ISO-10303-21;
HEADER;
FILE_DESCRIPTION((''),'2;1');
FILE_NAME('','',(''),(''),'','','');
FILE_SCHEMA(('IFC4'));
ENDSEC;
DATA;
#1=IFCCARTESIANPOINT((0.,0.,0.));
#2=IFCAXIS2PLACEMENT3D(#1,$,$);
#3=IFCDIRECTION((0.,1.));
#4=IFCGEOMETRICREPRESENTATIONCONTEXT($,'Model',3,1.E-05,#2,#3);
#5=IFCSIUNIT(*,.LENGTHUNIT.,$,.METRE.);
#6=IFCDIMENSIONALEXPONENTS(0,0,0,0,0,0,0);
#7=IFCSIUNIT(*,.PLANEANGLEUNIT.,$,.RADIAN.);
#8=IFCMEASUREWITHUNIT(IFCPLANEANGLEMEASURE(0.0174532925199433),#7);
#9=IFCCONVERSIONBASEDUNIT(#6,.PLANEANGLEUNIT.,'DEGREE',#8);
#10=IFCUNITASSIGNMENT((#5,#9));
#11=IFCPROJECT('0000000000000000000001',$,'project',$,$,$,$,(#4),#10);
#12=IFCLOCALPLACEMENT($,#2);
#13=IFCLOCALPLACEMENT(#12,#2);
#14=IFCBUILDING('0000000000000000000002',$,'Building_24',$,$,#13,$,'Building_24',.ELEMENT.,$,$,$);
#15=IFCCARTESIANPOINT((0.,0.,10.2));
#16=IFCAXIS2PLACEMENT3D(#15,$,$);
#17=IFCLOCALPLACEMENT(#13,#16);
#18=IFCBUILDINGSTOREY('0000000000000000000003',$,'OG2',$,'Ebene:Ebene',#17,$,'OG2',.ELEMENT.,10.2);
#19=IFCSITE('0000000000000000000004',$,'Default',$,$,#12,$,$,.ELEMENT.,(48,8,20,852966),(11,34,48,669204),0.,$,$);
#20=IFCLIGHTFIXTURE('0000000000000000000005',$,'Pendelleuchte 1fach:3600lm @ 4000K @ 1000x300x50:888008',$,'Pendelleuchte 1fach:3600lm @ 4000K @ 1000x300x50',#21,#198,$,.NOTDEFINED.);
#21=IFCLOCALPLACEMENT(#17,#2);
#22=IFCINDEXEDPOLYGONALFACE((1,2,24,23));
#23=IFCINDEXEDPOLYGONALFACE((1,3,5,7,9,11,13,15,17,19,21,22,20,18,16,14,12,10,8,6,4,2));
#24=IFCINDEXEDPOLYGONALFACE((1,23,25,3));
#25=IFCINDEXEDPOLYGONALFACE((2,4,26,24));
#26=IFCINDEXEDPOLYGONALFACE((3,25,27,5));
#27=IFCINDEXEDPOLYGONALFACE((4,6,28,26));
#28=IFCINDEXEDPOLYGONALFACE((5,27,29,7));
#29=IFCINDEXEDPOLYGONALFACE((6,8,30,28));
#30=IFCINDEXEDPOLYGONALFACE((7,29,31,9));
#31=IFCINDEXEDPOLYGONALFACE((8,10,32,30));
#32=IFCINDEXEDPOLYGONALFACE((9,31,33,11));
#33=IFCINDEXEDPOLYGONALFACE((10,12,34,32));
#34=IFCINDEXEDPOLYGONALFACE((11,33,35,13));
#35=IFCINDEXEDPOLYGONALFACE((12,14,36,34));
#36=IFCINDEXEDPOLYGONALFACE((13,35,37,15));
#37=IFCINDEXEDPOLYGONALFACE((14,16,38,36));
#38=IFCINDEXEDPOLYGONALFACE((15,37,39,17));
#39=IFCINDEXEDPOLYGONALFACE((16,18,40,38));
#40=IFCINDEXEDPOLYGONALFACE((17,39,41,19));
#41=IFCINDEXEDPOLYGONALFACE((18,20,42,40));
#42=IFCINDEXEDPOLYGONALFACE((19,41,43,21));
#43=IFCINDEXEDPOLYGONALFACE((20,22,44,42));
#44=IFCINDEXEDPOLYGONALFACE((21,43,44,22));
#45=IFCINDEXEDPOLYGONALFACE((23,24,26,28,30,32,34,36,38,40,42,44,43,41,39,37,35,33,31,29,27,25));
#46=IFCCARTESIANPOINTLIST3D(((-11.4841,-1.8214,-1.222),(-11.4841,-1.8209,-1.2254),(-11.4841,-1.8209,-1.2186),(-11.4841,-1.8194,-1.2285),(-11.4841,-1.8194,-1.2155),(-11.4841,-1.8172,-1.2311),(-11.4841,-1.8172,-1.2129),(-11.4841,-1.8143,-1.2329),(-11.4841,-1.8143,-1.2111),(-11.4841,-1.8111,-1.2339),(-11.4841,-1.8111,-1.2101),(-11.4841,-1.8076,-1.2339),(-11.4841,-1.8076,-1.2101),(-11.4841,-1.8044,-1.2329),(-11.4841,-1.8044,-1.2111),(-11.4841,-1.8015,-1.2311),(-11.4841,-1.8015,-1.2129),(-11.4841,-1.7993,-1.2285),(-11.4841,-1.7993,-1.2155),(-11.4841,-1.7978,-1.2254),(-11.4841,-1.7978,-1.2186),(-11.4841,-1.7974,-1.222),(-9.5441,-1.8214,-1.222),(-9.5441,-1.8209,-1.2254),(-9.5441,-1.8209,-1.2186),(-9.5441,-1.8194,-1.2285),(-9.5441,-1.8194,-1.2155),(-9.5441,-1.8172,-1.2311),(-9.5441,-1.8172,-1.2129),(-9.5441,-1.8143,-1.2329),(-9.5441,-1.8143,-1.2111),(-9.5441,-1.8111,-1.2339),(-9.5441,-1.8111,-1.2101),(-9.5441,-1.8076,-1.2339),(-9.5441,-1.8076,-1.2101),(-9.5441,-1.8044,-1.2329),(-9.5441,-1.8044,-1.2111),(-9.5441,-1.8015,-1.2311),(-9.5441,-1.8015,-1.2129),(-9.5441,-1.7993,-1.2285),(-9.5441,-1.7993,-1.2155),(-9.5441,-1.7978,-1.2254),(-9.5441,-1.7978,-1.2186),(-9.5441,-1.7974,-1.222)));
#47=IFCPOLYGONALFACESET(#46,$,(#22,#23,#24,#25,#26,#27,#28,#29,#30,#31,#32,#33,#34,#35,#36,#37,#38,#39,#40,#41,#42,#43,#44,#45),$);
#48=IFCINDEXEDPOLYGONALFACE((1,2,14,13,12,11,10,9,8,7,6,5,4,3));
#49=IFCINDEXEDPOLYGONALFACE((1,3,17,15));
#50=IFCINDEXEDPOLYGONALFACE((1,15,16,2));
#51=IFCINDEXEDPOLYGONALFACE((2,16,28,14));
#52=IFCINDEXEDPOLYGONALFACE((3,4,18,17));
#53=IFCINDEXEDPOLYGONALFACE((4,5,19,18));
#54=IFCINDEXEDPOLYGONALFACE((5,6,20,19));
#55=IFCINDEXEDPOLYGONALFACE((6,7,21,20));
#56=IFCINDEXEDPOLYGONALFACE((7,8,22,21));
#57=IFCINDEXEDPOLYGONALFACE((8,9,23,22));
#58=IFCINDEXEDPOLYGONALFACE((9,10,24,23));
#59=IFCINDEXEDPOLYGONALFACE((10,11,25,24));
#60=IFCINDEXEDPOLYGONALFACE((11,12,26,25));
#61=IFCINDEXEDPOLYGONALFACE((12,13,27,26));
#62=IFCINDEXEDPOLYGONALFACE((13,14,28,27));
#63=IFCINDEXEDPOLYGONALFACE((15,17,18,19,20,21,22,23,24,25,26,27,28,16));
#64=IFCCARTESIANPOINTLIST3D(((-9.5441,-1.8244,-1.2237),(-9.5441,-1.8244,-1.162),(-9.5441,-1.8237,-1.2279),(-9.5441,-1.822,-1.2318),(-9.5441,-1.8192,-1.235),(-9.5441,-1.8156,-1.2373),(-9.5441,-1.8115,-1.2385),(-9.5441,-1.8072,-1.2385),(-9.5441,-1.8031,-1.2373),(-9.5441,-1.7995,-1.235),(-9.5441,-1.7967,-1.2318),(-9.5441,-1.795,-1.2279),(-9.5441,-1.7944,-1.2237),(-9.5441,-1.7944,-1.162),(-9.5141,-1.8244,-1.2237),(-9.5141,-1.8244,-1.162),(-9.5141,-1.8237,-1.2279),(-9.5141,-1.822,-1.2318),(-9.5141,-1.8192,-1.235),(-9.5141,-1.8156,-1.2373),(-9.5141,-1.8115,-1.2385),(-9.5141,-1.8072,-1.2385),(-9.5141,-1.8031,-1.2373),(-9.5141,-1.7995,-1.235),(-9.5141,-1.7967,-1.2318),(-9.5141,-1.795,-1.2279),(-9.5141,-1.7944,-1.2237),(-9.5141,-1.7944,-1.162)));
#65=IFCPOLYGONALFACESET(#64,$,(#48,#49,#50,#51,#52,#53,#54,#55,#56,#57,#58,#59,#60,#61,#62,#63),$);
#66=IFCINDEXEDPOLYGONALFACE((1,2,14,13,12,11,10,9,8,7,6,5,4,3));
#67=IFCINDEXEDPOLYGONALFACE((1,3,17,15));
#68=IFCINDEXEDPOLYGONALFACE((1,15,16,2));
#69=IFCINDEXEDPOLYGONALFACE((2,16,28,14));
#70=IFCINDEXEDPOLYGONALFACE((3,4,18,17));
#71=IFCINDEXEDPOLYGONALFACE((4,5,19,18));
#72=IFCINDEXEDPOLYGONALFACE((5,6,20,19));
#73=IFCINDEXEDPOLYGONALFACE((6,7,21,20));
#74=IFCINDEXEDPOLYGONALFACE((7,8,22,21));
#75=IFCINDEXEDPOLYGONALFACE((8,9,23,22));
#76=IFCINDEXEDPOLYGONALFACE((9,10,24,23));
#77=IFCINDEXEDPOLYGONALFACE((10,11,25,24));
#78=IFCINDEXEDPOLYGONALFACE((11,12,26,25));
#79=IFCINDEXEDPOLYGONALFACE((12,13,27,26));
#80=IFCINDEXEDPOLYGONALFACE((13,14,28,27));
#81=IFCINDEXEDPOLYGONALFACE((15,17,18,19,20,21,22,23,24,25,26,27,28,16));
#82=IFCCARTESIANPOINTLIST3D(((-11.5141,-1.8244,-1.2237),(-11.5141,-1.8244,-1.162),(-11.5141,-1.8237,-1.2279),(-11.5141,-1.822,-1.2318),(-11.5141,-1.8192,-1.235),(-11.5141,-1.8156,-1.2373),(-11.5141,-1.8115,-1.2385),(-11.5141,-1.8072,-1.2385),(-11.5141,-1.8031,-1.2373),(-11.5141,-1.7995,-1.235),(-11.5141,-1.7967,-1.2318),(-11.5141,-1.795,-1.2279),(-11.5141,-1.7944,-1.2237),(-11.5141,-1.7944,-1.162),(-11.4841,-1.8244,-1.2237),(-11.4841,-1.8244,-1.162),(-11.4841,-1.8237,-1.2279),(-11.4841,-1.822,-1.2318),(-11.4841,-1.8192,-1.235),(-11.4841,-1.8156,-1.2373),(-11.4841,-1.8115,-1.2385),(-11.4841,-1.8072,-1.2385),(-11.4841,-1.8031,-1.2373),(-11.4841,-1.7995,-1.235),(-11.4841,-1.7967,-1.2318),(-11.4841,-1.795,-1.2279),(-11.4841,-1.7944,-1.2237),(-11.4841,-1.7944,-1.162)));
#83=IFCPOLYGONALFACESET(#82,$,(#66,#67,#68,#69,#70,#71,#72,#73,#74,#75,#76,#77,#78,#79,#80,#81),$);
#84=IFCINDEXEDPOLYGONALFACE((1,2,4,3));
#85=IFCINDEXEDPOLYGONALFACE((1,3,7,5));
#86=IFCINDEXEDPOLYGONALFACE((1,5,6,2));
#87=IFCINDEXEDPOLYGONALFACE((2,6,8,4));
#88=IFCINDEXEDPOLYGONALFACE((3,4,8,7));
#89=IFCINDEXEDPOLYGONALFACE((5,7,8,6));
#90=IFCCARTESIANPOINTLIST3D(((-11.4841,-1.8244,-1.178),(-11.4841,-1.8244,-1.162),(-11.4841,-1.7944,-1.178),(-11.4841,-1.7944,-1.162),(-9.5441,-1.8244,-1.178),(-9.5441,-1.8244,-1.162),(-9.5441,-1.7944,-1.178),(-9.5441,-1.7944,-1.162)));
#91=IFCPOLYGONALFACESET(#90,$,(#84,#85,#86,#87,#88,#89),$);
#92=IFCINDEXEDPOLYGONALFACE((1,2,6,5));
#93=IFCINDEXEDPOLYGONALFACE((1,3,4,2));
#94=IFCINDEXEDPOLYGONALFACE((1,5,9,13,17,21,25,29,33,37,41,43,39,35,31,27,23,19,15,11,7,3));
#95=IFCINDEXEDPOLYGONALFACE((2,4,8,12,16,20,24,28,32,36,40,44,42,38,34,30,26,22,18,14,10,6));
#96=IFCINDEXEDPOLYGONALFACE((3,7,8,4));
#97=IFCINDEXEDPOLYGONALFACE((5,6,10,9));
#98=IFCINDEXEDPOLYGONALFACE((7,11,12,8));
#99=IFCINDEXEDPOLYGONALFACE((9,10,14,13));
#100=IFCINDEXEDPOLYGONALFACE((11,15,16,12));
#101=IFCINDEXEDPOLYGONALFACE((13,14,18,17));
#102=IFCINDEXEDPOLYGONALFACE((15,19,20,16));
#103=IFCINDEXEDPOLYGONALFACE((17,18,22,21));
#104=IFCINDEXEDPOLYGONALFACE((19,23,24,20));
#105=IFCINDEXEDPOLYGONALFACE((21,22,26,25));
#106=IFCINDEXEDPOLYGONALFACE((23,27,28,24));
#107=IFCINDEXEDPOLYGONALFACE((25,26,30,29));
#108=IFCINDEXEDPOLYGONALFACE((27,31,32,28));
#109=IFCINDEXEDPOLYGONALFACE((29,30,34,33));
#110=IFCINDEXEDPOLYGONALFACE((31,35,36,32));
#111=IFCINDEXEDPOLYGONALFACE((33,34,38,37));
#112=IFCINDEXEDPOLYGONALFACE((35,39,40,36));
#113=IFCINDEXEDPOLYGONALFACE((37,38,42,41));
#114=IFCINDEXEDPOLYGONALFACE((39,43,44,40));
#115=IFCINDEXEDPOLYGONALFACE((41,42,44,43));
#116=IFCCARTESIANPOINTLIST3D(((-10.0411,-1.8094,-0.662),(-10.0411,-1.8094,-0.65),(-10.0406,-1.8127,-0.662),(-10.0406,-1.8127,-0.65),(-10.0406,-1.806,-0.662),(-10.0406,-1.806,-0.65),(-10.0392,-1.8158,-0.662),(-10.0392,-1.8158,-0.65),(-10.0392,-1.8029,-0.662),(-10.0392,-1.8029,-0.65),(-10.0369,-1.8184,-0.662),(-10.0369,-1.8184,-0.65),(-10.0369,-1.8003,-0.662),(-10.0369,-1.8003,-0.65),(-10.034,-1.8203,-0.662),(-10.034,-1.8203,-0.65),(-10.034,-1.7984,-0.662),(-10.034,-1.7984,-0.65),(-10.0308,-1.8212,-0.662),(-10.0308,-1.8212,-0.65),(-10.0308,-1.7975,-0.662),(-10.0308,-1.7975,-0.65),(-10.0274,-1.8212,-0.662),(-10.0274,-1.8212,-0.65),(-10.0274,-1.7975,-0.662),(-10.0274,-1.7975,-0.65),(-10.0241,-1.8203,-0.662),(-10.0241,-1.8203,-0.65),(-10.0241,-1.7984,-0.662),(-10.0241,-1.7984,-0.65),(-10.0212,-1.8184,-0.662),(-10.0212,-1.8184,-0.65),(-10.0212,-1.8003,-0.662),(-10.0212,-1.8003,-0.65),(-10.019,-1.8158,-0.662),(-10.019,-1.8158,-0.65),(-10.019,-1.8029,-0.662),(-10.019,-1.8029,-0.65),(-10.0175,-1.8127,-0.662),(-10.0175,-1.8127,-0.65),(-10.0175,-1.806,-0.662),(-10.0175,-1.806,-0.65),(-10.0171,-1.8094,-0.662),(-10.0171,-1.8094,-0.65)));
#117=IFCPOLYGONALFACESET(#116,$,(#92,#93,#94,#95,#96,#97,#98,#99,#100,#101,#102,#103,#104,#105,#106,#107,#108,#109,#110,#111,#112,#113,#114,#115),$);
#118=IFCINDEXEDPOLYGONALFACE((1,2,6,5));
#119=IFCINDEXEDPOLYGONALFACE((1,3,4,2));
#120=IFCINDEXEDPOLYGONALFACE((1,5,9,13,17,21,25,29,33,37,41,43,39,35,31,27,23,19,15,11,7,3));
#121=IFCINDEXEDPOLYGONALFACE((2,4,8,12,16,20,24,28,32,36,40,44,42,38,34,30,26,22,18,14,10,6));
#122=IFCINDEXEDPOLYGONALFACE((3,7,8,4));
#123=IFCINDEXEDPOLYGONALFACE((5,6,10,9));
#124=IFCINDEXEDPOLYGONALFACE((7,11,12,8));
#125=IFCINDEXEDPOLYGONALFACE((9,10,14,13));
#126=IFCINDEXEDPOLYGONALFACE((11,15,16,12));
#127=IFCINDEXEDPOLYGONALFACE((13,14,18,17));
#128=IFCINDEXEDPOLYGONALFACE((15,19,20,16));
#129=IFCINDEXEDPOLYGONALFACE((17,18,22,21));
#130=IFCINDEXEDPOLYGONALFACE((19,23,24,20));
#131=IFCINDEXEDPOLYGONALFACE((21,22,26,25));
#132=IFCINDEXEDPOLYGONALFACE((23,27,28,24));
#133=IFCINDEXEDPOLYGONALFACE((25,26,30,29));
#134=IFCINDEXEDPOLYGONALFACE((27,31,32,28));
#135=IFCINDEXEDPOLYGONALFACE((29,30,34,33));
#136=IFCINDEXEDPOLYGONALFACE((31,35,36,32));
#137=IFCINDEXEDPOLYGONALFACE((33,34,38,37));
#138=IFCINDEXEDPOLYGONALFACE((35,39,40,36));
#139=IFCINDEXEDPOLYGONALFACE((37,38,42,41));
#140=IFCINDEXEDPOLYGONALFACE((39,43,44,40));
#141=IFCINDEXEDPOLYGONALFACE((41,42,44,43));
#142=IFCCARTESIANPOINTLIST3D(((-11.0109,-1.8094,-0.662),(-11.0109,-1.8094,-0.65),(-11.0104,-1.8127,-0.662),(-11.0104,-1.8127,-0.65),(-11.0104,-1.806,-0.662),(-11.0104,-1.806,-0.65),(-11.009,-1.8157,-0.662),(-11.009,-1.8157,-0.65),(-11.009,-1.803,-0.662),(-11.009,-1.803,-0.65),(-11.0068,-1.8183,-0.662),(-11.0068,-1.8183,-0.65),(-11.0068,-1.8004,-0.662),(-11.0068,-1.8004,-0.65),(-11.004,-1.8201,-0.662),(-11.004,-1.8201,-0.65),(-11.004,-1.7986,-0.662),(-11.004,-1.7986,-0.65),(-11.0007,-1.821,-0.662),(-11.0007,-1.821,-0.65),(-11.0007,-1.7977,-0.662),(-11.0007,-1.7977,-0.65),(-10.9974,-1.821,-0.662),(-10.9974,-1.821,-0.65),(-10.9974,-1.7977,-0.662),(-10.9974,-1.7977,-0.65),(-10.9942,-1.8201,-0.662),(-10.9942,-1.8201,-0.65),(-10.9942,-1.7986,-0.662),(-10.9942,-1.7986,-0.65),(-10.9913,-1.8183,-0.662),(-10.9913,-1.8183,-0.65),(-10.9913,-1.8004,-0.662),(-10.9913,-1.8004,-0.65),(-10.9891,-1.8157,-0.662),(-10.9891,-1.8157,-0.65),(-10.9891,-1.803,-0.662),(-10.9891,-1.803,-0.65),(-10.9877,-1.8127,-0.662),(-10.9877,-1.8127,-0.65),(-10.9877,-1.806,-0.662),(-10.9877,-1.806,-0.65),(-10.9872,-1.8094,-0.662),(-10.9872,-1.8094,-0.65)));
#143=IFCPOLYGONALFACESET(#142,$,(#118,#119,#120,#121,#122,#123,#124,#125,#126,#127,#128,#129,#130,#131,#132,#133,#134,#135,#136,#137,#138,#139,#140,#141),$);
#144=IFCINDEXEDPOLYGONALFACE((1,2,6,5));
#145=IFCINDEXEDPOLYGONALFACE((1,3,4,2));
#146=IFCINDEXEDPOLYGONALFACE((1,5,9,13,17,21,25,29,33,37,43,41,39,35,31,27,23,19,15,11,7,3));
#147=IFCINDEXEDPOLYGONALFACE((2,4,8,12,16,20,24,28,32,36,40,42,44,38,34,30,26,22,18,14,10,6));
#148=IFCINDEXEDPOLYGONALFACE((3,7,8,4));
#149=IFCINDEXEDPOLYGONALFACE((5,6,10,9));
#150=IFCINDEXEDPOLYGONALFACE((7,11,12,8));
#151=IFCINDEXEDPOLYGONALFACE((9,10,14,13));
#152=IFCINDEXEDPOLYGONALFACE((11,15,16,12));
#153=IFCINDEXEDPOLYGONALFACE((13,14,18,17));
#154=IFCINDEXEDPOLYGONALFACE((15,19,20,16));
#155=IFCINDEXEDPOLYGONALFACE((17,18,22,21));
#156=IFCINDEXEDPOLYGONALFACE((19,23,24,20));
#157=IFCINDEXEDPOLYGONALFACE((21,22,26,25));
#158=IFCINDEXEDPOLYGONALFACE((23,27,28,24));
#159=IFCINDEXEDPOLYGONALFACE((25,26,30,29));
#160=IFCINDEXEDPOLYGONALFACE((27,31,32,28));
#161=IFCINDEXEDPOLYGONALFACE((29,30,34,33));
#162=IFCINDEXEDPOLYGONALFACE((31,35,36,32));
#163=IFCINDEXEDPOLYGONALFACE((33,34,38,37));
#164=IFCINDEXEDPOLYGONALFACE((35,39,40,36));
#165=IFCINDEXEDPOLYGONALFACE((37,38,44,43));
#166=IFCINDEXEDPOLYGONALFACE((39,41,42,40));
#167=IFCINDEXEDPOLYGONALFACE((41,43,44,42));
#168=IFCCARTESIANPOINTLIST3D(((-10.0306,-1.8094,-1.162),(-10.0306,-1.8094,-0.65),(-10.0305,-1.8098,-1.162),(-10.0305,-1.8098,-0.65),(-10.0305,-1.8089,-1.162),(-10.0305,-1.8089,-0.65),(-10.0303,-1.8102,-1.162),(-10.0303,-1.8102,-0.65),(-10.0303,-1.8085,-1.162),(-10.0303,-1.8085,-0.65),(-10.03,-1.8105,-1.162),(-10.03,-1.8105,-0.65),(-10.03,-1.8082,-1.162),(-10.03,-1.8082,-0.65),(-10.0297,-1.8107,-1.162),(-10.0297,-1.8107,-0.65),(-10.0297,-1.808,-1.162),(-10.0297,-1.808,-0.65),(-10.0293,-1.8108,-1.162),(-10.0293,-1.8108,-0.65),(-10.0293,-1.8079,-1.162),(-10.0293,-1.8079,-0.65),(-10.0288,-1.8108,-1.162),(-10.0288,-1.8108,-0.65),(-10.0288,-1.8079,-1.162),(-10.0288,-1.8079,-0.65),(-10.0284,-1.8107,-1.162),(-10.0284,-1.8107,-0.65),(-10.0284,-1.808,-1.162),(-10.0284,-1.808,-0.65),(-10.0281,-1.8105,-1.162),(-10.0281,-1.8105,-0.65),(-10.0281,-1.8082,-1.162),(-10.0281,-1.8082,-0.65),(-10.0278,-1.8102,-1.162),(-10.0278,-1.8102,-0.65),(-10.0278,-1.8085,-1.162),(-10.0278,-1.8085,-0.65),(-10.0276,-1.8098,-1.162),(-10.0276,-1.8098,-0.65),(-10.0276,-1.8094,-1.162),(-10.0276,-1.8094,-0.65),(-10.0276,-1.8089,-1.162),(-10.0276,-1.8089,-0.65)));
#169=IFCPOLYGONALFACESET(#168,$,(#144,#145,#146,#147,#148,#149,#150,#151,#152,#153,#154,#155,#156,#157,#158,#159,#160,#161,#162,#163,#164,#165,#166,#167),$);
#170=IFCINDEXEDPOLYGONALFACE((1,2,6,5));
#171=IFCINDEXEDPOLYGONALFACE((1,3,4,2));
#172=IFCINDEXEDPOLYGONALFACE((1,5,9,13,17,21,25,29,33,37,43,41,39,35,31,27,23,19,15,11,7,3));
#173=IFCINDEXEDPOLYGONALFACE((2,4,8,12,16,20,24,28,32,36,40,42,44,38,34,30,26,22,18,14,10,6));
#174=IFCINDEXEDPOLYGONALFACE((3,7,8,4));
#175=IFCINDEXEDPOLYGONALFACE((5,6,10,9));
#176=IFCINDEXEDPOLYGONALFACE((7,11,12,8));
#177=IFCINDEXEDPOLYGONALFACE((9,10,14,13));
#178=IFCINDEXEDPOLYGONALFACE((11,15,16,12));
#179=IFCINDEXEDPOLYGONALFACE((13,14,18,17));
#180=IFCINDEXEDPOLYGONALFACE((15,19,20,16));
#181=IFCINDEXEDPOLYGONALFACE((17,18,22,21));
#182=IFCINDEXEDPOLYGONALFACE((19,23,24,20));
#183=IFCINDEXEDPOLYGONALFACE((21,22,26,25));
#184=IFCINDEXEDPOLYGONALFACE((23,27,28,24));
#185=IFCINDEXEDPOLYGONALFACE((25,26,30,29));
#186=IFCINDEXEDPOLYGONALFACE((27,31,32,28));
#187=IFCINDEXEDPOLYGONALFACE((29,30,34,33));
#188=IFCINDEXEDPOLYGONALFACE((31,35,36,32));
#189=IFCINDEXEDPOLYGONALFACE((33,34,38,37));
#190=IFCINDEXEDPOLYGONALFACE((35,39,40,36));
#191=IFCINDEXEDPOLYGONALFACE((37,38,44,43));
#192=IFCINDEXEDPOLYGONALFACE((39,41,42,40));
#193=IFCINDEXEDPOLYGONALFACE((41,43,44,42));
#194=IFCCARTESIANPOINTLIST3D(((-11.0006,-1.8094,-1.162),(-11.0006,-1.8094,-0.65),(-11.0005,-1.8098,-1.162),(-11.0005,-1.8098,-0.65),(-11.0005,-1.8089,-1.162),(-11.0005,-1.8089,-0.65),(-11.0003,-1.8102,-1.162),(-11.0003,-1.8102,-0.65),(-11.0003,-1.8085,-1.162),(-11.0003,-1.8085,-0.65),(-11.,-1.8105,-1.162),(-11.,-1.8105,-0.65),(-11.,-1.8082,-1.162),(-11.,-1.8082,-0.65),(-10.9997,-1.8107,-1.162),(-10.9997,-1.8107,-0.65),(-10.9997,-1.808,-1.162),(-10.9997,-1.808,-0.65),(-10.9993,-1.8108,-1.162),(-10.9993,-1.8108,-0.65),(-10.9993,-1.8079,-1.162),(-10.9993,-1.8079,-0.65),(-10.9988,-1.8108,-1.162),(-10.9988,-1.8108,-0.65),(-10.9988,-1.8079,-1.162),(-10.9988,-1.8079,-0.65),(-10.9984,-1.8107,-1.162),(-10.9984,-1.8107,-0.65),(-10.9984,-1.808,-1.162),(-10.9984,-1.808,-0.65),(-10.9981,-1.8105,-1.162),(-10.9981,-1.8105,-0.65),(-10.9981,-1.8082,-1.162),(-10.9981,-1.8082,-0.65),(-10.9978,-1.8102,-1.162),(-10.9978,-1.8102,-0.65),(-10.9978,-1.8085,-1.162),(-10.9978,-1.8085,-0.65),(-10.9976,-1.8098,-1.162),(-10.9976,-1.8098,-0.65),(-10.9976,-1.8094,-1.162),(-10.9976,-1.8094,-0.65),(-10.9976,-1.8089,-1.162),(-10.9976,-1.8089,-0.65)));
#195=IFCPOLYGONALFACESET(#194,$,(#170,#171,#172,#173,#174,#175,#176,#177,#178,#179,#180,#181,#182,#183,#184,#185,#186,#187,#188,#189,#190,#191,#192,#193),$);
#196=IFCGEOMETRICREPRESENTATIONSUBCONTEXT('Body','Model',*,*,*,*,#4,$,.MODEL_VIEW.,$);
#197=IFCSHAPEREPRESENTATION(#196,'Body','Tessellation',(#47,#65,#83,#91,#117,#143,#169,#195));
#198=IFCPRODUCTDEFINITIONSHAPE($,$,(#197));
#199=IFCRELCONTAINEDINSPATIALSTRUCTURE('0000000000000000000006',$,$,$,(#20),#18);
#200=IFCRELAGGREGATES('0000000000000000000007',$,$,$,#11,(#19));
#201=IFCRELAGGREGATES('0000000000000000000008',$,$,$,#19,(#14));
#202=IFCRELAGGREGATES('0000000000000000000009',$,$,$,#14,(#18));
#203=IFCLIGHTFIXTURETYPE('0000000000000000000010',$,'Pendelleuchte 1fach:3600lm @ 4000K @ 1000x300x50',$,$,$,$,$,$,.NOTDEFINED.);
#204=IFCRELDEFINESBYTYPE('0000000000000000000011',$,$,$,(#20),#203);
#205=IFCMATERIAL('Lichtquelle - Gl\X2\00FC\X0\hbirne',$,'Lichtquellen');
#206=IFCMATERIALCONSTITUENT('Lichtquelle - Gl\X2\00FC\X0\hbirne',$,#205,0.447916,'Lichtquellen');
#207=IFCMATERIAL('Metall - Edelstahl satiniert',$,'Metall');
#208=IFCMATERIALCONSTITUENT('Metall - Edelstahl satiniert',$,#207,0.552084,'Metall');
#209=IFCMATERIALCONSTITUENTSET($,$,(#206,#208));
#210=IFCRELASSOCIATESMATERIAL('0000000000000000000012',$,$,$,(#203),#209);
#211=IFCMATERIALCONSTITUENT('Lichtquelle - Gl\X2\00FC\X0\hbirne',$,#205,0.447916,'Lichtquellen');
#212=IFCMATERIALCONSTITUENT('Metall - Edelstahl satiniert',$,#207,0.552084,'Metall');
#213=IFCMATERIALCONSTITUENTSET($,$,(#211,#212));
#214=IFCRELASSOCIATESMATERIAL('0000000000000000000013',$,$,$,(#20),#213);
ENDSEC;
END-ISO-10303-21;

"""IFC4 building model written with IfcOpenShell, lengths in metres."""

from ifc_helpers import new_model, entity, si_unit, converted_unit, direction, frame, origin, place, context, subcontext, project, spatial, line, arc, indexed_curve, outline, extrude, source, transform, mapped, material, constituent, constituent_set, type_object, type_shapes, element, save


model = new_model("IFC4")

# Units and contexts
model_context = context("Model", 3, precision=1e-05, world=origin(), true_north=direction((0.0, 1.0)))
body_context = subcontext(model_context, "Body", "Model", "MODEL_VIEW")
ifc_project = project(units=[si_unit("LENGTHUNIT", "METRE"), converted_unit("PLANEANGLEUNIT", "DEGREE", entity("IfcPlaneAngleMeasure", 0.0174532925199433), si_unit("PLANEANGLEUNIT", "RADIAN"), dimensions=[0, 0, 0, 0, 0, 0, 0])], contexts=[model_context])

# Site, building, storey
site_placement = place(None, origin())
site = spatial("IfcSite", under=ifc_project, at=site_placement, Name="Default", CompositionType="ELEMENT", RefLatitude=(48, 8, 20, 852966), RefLongitude=(11, 34, 48, 669204), RefElevation=0.0)
building_placement = place(site_placement, origin())
building = spatial("IfcBuilding", under=site, at=building_placement, Name="Building_24", LongName="Building_24", CompositionType="ELEMENT")
storey_placement = place(building_placement, frame((0.0, 0.0, 10.2)))
storey = spatial("IfcBuildingStorey", under=building, at=storey_placement, Name="OG2", ObjectType="Ebene:Ebene", LongName="OG2", CompositionType="ELEMENT", Elevation=10.2)

# Light fixture
ifc_material_1 = material(Name="Lichtquelle - Glühbirne", Category="Lichtquellen")
ifc_material_2 = material(Name="Metall - Edelstahl satiniert", Category="Metall")
ifc_constituent_1 = constituent(ifc_material_1, Name="Lichtquelle - Glühbirne", Category="Lichtquellen", fraction=0.447916)
ifc_constituent_2 = constituent(ifc_material_2, Name="Metall - Edelstahl satiniert", Category="Metall", fraction=0.552084)
ifc_constituent_set_1 = constituent_set(constituents=[ifc_constituent_1, ifc_constituent_2])
light_fixture_type_1 = type_object("IfcLightFixtureType", Name="Pendelleuchte 1fach:3600lm @ 4000K @ 1000x300x50", PredefinedType="NOTDEFINED", material=ifc_constituent_set_1)
shared_shape_1 = source(origin(), body_context, "Body", "SweptSolid", [
    extrude(outline(indexed_curve([(-0.012, 0.0), (0.0, -0.012), (0.012, 0.0), (0.0, 0.012)], segments=[arc(1, 2, 3), arc(3, 4, 1)], self_intersect=False)), frame((-0.97, 0.0, -0.572), z_axis=(1.0, 0.0, 0.0), x_axis=(0.0, 1.0, 0.0)), (0.0, 0.0, 1.0), 1.94),
    extrude(outline(indexed_curve([(-0.0308, -0.015), (0.0308, -0.015), (0.0308, 0.015), (-0.0308, 0.015), (-0.0458, 0.0)], segments=[line(1, 2, 3, 4), arc(4, 5, 1)], self_intersect=False)), frame((0.97, 0.0, -0.5428), z_axis=(1.0, 0.0, 0.0), x_axis=(0.0, 0.0, 1.0)), (0.0, 0.0, 1.0), 0.03),
    extrude(outline(indexed_curve([(-0.0308, -0.015), (0.0308, -0.015), (0.0308, 0.015), (-0.0308, 0.015), (-0.0458, 0.0)], segments=[line(1, 2, 3, 4), arc(4, 5, 1)], self_intersect=False)), frame((-1.0, 0.0, -0.5428), z_axis=(1.0, 0.0, 0.0), x_axis=(0.0, 0.0, 1.0)), (0.0, 0.0, 1.0), 0.03),
    extrude(outline(indexed_curve([(-0.97, -0.015), (0.97, -0.015), (0.97, 0.015), (-0.97, 0.015), (-0.97, -0.015)], self_intersect=False)), frame((0.0, 0.0, -0.528), z_axis=(0.0, 0.0, 1.0), x_axis=(-1.0, 0.0, 0.0)), (0.0, 0.0, 1.0), 0.016),
    extrude(outline(indexed_curve([(-0.012, 0.0), (0.0, -0.012), (0.012, 0.0), (0.0, 0.012)], segments=[arc(1, 2, 3), arc(3, 4, 1)], self_intersect=False)), frame((0.485, 0.0, -0.012)), (0.0, 0.0, 1.0), 0.012),
    extrude(outline(indexed_curve([(-0.0118, 0.0), (0.0, -0.0118), (0.0118, 0.0), (0.0, 0.0118)], segments=[arc(1, 2, 3), arc(3, 4, 1)], self_intersect=False)), frame((-0.485, 0.0, -0.012)), (0.0, 0.0, 1.0), 0.012),
    extrude(outline(indexed_curve([(-0.0015, 0.0), (0.0, -0.0015), (0.0015, 0.0), (0.0, 0.0015)], segments=[arc(1, 2, 3), arc(3, 4, 1)], self_intersect=False)), frame((0.485, 0.0, -0.512)), (0.0, 0.0, 1.0), 0.512),
    extrude(outline(indexed_curve([(-0.0015, 0.0), (0.0, -0.0015), (0.0015, 0.0), (0.0, 0.0015)], segments=[arc(1, 2, 3), arc(3, 4, 1)], self_intersect=False)), frame((-0.485, 0.0, -0.512)), (0.0, 0.0, 1.0), 0.512),
])
type_shapes(light_fixture_type_1, [shared_shape_1])
ifc_constituent_3 = constituent(ifc_material_1, Name="Lichtquelle - Glühbirne", Category="Lichtquellen", fraction=0.447916)
ifc_constituent_4 = constituent(ifc_material_2, Name="Metall - Edelstahl satiniert", Category="Metall", fraction=0.552084)
ifc_constituent_set_2 = constituent_set(constituents=[ifc_constituent_3, ifc_constituent_4])
light_fixture_1_placement = place(storey_placement, frame((-10.5141, -1.8094, -0.65)))
element("IfcLightFixture", 1, at=light_fixture_1_placement, inside=storey, type_object=light_fixture_type_1, material=ifc_constituent_set_2, Name="Pendelleuchte 1fach:3600lm @ 4000K @ 1000x300x50:888008", ObjectType="Pendelleuchte 1fach:3600lm @ 4000K @ 1000x300x50", PredefinedType="NOTDEFINED", context=body_context, shape_type="MappedRepresentation", body=[
    mapped(shared_shape_1, transform((0.0, 0.0, 0.0), scale=1.0)),
])

save(model, "model.ifc")
